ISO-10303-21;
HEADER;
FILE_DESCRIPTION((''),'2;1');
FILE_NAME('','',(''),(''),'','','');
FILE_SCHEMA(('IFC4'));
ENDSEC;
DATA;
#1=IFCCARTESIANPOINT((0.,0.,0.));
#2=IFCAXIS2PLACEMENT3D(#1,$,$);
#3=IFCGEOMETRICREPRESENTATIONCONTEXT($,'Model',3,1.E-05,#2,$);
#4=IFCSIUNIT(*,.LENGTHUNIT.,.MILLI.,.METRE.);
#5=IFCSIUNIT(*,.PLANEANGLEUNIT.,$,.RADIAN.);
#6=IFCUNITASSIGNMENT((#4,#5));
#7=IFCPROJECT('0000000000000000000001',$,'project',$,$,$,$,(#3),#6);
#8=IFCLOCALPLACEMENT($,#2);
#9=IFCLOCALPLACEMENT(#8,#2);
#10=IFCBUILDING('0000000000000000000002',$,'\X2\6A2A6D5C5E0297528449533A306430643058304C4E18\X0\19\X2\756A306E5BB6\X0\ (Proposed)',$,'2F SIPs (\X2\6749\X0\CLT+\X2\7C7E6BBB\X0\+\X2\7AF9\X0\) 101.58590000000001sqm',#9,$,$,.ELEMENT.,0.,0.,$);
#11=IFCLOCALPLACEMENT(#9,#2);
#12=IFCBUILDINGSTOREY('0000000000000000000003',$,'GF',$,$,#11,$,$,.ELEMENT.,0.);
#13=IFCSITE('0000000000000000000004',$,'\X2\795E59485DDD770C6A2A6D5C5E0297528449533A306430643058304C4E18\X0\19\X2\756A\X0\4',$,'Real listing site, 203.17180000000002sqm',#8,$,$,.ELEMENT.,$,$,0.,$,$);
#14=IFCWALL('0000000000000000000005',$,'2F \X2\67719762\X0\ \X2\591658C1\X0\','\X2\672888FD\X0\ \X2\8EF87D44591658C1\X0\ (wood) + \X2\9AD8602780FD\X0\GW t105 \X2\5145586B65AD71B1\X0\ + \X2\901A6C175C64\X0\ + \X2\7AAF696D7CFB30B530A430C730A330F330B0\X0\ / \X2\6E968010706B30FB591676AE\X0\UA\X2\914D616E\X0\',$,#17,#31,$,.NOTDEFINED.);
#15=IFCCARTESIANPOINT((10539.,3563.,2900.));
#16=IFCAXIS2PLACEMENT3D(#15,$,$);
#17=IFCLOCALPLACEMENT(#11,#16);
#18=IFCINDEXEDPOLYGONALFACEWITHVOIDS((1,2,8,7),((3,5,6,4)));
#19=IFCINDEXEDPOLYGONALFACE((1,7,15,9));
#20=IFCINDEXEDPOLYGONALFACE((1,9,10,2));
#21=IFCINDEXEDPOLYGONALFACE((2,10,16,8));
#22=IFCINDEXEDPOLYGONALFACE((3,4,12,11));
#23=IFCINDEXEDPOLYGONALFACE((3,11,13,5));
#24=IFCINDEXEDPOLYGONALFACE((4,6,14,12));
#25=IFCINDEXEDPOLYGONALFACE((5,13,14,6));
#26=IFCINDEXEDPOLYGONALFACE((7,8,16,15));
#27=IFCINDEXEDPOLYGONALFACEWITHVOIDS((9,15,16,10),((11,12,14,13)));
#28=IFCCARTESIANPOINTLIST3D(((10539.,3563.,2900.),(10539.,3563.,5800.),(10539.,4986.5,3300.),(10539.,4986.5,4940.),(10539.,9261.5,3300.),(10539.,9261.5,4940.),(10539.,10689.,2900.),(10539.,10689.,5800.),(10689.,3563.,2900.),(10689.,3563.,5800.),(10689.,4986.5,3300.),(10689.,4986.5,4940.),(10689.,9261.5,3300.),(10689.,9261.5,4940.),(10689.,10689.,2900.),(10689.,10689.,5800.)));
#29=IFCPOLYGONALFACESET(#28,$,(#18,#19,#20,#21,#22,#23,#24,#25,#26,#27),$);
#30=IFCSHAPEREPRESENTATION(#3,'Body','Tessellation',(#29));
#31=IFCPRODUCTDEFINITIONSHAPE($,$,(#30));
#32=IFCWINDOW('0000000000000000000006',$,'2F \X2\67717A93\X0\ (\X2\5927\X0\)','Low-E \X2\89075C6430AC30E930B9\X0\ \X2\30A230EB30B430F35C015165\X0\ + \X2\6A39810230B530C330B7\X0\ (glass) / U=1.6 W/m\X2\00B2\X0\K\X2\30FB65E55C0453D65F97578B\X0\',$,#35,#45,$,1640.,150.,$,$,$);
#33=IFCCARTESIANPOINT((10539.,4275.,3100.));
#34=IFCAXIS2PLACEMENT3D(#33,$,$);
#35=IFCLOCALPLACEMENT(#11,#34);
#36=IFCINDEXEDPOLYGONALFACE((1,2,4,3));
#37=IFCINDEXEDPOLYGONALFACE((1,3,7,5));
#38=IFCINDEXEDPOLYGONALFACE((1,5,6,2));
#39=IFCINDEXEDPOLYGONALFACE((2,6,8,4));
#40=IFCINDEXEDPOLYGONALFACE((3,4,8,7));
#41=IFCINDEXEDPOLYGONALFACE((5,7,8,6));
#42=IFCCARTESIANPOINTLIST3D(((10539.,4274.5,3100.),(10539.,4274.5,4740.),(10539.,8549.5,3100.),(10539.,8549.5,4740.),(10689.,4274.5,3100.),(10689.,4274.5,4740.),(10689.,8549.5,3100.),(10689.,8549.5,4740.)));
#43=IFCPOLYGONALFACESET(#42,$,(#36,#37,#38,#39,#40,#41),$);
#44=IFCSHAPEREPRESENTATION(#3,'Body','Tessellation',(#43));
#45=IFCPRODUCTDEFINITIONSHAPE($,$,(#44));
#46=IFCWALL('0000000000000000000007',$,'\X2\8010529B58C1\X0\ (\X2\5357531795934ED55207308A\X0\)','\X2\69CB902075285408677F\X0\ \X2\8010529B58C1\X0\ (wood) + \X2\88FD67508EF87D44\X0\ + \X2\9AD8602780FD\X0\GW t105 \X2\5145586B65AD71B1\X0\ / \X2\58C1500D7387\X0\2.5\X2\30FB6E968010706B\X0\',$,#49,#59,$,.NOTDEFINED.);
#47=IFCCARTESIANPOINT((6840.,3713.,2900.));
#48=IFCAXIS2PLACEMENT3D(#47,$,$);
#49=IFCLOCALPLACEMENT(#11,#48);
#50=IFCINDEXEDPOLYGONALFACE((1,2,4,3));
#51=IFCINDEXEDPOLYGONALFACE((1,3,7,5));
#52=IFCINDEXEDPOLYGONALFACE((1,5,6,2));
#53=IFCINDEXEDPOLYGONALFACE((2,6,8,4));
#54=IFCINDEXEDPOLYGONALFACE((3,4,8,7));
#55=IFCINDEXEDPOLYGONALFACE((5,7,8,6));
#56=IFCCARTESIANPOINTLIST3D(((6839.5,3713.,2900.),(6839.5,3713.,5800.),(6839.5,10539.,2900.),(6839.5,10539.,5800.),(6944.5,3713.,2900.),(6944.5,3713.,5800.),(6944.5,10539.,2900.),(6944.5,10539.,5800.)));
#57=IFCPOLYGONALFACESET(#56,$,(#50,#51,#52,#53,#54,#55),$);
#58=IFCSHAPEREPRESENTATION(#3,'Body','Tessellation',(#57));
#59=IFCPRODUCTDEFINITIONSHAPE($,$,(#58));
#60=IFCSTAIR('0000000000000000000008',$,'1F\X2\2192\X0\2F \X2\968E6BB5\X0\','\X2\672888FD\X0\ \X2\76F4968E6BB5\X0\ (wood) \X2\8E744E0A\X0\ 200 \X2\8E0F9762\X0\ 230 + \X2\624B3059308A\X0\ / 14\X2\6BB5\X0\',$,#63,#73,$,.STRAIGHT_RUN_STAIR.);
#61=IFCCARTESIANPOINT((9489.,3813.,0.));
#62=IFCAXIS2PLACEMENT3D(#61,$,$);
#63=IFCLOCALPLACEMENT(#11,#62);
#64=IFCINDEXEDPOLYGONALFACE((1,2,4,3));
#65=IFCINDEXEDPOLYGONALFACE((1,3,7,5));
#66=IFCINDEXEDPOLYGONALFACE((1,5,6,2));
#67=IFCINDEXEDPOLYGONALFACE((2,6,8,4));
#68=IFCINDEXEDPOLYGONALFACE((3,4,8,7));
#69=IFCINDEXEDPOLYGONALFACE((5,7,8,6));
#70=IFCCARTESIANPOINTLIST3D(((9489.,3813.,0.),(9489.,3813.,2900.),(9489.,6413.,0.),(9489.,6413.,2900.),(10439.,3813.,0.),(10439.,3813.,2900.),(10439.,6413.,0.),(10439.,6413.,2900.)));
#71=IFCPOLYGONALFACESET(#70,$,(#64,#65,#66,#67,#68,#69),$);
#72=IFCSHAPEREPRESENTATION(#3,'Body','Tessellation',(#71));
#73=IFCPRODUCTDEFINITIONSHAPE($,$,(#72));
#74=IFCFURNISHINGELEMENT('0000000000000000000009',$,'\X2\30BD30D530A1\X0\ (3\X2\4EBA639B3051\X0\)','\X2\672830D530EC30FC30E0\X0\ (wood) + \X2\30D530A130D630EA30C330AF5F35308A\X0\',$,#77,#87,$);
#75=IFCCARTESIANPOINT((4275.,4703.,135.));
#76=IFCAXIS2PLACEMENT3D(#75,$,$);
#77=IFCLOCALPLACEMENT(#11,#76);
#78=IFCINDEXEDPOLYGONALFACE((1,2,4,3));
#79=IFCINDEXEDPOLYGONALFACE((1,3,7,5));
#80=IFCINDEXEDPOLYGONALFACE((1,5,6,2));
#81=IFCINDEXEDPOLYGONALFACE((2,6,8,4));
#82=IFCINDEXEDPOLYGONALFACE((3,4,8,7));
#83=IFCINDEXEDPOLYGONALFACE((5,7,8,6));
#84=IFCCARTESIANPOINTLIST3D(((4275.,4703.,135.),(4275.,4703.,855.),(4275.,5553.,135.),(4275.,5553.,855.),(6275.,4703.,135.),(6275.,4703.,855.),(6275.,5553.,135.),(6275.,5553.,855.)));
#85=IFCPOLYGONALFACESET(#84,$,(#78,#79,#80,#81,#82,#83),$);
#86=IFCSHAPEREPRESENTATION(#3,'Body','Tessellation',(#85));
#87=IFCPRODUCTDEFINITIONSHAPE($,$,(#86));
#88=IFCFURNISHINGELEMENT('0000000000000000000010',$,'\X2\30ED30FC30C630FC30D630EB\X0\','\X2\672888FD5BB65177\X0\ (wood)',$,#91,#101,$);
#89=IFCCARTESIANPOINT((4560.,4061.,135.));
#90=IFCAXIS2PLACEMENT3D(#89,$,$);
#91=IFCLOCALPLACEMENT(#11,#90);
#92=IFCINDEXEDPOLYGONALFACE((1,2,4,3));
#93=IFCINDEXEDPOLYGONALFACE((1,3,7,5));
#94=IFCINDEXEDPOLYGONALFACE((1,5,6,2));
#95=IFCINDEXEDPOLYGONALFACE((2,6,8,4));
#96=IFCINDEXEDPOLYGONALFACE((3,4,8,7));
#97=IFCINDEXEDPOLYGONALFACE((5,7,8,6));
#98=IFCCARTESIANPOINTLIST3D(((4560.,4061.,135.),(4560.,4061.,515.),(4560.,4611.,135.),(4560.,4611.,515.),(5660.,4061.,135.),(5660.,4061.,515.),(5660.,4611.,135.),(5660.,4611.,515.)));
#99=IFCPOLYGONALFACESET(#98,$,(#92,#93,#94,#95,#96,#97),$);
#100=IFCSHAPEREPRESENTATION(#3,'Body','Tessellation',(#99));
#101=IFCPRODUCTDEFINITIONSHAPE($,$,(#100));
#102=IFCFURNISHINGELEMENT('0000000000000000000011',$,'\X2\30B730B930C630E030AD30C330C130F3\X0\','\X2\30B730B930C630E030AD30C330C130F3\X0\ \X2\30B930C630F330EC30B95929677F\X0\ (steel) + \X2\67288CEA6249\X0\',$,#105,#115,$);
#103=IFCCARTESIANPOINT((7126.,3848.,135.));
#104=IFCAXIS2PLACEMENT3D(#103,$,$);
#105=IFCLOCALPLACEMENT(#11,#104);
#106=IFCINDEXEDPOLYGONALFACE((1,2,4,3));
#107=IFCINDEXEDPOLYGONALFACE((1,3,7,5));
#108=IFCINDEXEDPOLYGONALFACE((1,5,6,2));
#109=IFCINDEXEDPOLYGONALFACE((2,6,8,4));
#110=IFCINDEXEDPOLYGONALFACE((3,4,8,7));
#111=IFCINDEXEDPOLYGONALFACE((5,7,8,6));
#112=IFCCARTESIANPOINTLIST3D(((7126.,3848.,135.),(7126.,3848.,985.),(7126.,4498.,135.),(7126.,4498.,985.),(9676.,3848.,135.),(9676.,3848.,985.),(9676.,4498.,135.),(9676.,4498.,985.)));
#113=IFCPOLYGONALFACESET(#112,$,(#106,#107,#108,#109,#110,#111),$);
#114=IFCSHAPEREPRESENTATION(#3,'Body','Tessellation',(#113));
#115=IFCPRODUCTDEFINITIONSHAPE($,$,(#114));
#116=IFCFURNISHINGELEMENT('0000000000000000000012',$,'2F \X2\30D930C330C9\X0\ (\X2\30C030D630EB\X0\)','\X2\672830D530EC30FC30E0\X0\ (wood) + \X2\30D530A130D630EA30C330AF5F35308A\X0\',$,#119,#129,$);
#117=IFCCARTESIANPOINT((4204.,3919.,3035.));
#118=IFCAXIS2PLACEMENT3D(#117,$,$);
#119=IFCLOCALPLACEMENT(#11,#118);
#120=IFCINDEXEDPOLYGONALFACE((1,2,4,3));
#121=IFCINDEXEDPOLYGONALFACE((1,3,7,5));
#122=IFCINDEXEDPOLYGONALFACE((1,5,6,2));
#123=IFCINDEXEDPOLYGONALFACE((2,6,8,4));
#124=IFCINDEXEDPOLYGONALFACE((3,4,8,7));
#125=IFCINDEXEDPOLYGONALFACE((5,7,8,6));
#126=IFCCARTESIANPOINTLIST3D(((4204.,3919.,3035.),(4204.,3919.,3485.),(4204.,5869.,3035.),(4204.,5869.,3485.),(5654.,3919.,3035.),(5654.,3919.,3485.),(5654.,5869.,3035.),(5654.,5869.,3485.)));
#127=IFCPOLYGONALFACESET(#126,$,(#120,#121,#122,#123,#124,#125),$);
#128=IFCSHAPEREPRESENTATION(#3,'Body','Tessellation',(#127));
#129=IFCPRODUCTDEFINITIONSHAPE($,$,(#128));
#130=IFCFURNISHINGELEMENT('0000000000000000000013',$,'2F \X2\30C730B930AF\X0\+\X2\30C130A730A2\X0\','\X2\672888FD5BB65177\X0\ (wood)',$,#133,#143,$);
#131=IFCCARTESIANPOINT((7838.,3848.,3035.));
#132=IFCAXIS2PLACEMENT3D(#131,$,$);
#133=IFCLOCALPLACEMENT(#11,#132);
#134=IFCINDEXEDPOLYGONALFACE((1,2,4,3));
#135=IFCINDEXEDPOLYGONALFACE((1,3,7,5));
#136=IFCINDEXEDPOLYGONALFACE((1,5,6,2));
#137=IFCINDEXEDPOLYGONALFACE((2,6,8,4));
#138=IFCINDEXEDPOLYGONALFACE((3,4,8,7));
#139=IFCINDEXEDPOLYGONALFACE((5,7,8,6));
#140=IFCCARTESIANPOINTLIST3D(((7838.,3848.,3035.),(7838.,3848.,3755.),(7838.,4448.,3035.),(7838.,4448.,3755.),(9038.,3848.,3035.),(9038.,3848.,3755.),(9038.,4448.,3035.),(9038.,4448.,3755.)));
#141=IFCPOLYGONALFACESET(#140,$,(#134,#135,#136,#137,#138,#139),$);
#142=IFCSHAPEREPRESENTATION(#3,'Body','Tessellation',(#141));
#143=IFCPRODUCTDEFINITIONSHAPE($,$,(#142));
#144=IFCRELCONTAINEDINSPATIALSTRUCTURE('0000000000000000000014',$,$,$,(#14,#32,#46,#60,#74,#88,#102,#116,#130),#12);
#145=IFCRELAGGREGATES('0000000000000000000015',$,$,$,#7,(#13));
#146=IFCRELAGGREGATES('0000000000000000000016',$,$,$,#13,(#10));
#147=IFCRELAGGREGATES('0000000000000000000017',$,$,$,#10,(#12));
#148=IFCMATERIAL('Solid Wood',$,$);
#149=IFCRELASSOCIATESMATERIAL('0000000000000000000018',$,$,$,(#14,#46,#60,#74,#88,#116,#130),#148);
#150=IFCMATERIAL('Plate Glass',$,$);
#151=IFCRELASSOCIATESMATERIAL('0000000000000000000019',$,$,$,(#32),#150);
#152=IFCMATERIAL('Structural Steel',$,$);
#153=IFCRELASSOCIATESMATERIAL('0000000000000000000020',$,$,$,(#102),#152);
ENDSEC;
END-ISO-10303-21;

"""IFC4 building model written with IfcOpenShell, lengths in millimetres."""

from ifc_helpers import new_model, si_unit, frame, frame_2d, origin, place, context, project, spatial, rectangle, extrude, material, element, fill, save


model = new_model("IFC4")

# Units and contexts
model_context = context("Model", 3, precision=1e-05, world=origin())
ifc_project = project(units=[si_unit("LENGTHUNIT", "METRE", prefix="MILLI"), si_unit("PLANEANGLEUNIT", "RADIAN")], contexts=[model_context])

# Site, building, storey
site_placement = place(None, origin())
site = spatial("IfcSite", under=ifc_project, at=site_placement, Name="神奈川県横浜市青葉区つつじが丘19番4", ObjectType="Real listing site, 203.17180000000002sqm", CompositionType="ELEMENT", RefElevation=0.0)
building_placement = place(site_placement, origin())
building = spatial("IfcBuilding", under=site, at=building_placement, Name="横浜市青葉区つつじが丘19番の家 (Proposed)", ObjectType="2F SIPs (杉CLT+籾殻+竹) 101.58590000000001sqm", CompositionType="ELEMENT", ElevationOfRefHeight=0.0, ElevationOfTerrain=0.0)
storey_placement = place(building_placement, origin())
storey = spatial("IfcBuildingStorey", under=building, at=storey_placement, Name="GF", CompositionType="ELEMENT", Elevation=0.0)

# Shared definitions
ifc_material_1 = material(Name="Solid Wood")
ifc_material_2 = material(Name="Plate Glass")

# Wall, opening, window
wall_1_placement = place(storey_placement, frame((10539.0, 3563.0, 2900.0)))
wall_1 = element("IfcWall", 1, at=wall_1_placement, inside=storey, material=ifc_material_1, Name="2F 東面 外壁", Description="木製 軸組外壁 (wood) + 高性能GW t105 充填断熱 + 通気層 + 窯業系サイディング / 準耐火・外皮UA配慮", PredefinedType="NOTDEFINED", context=model_context, shape_type="SweptSolid", body=[
    extrude(rectangle(XDim=150.0, YDim=7126.0, at=frame_2d((75.0, 3563.0))), frame((10539.0, 3563.0, 2900.0)), (0.0, 0.0, 1.0), 2900.0),
])
opening_1_placement = place(storey_placement, frame((10539.0, 4275.0, 3100.0)))
opening_1 = element("IfcOpeningElement", 2, at=opening_1_placement, cuts=wall_1, PredefinedType="NOTDEFINED", context=model_context, shape_type="SweptSolid", body=[
    extrude(rectangle(XDim=150.0, YDim=4275.0, at=frame_2d((75.0, 2137.0))), frame((10539.0, 4275.0, 3100.0)), (0.0, 0.0, 1.0), 1640.0),
])
window_1_placement = place(storey_placement, frame((10539.0, 4275.0, 3100.0)))
window_1 = element("IfcWindow", 3, at=window_1_placement, inside=storey, material=ifc_material_2, Name="2F 東窓 (大)", Description="Low-E 複層ガラス アルゴン封入 + 樹脂サッシ (glass) / U=1.6 W/m²K・日射取得型", OverallHeight=1640.0, OverallWidth=150.0, context=model_context, shape_type="SweptSolid", body=[
    extrude(rectangle(XDim=150.0, YDim=4275.0, at=frame_2d((75.0, 2137.0))), frame((10539.0, 4275.0, 3100.0)), (0.0, 0.0, 1.0), 1640.0),
])
fill(opening_1, window_1)

# Wall
wall_2_placement = place(storey_placement, frame((6840.0, 3713.0, 2900.0)))
element("IfcWall", 4, at=wall_2_placement, inside=storey, material=ifc_material_1, Name="耐力壁 (南北間仕切り)", Description="構造用合板 耐力壁 (wood) + 製材軸組 + 高性能GW t105 充填断熱 / 壁倍率2.5・準耐火", PredefinedType="NOTDEFINED", context=model_context, shape_type="SweptSolid", body=[
    extrude(rectangle(XDim=105.0, YDim=6826.0, at=frame_2d((52.0, 3413.0))), frame((6840.0, 3713.0, 2900.0)), (0.0, 0.0, 1.0), 2900.0),
])

# Stair
stair_placement = place(storey_placement, frame((9489.0, 3813.0, 0.0)))
element("IfcStair", 5, at=stair_placement, inside=storey, material=ifc_material_1, Name="1F→2F 階段", Description="木製 直階段 (wood) 蹴上 200 踏面 230 + 手すり / 14段", PredefinedType="STRAIGHT_RUN_STAIR", context=model_context, shape_type="SweptSolid", body=[
    extrude(rectangle(XDim=950.0, YDim=2600.0, at=frame_2d((475.0, 1300.0))), frame((9489.0, 3813.0, 0.0)), (0.0, 0.0, 1.0), 2900.0),
])

# Furnishing elements
furnishing_1_placement = place(storey_placement, frame((4275.0, 4703.0, 135.0)))
element("IfcFurnishingElement", 6, at=furnishing_1_placement, inside=storey, material=ifc_material_1, Name="ソファ (3人掛け)", Description="木フレーム (wood) + ファブリック張り", context=model_context, shape_type="SweptSolid", body=[
    extrude(rectangle(XDim=2000.0, YDim=850.0, at=frame_2d((1000.0, 425.0))), frame((4275.0, 4703.0, 135.0)), (0.0, 0.0, 1.0), 720.0),
])
furnishing_2_placement = place(storey_placement, frame((4560.0, 4061.0, 135.0)))
element("IfcFurnishingElement", 7, at=furnishing_2_placement, inside=storey, material=ifc_material_1, Name="ローテーブル", Description="木製家具 (wood)", context=model_context, shape_type="SweptSolid", body=[
    extrude(rectangle(XDim=1100.0, YDim=550.0, at=frame_2d((550.0, 275.0))), frame((4560.0, 4061.0, 135.0)), (0.0, 0.0, 1.0), 380.0),
])
ifc_material_3 = material(Name="Structural Steel")
furnishing_3_placement = place(storey_placement, frame((7126.0, 3848.0, 135.0)))
element("IfcFurnishingElement", 8, at=furnishing_3_placement, inside=storey, material=ifc_material_3, Name="システムキッチン", Description="システムキッチン ステンレス天板 (steel) + 木質扉", context=model_context, shape_type="SweptSolid", body=[
    extrude(rectangle(XDim=2550.0, YDim=650.0, at=frame_2d((1275.0, 325.0))), frame((7126.0, 3848.0, 135.0)), (0.0, 0.0, 1.0), 850.0),
])
furnishing_4_placement = place(storey_placement, frame((4204.0, 3919.0, 3035.0)))
element("IfcFurnishingElement", 9, at=furnishing_4_placement, inside=storey, material=ifc_material_1, Name="2F ベッド (ダブル)", Description="木フレーム (wood) + ファブリック張り", context=model_context, shape_type="SweptSolid", body=[
    extrude(rectangle(XDim=1450.0, YDim=1950.0, at=frame_2d((725.0, 975.0))), frame((4204.0, 3919.0, 3035.0)), (0.0, 0.0, 1.0), 450.0),
])
furnishing_5_placement = place(storey_placement, frame((7838.0, 3848.0, 3035.0)))
element("IfcFurnishingElement", 10, at=furnishing_5_placement, inside=storey, material=ifc_material_1, Name="2F デスク+チェア", Description="木製家具 (wood)", context=model_context, shape_type="SweptSolid", body=[
    extrude(rectangle(XDim=1200.0, YDim=600.0, at=frame_2d((600.0, 300.0))), frame((7838.0, 3848.0, 3035.0)), (0.0, 0.0, 1.0), 720.0),
])

save(model, "model.ifc")
